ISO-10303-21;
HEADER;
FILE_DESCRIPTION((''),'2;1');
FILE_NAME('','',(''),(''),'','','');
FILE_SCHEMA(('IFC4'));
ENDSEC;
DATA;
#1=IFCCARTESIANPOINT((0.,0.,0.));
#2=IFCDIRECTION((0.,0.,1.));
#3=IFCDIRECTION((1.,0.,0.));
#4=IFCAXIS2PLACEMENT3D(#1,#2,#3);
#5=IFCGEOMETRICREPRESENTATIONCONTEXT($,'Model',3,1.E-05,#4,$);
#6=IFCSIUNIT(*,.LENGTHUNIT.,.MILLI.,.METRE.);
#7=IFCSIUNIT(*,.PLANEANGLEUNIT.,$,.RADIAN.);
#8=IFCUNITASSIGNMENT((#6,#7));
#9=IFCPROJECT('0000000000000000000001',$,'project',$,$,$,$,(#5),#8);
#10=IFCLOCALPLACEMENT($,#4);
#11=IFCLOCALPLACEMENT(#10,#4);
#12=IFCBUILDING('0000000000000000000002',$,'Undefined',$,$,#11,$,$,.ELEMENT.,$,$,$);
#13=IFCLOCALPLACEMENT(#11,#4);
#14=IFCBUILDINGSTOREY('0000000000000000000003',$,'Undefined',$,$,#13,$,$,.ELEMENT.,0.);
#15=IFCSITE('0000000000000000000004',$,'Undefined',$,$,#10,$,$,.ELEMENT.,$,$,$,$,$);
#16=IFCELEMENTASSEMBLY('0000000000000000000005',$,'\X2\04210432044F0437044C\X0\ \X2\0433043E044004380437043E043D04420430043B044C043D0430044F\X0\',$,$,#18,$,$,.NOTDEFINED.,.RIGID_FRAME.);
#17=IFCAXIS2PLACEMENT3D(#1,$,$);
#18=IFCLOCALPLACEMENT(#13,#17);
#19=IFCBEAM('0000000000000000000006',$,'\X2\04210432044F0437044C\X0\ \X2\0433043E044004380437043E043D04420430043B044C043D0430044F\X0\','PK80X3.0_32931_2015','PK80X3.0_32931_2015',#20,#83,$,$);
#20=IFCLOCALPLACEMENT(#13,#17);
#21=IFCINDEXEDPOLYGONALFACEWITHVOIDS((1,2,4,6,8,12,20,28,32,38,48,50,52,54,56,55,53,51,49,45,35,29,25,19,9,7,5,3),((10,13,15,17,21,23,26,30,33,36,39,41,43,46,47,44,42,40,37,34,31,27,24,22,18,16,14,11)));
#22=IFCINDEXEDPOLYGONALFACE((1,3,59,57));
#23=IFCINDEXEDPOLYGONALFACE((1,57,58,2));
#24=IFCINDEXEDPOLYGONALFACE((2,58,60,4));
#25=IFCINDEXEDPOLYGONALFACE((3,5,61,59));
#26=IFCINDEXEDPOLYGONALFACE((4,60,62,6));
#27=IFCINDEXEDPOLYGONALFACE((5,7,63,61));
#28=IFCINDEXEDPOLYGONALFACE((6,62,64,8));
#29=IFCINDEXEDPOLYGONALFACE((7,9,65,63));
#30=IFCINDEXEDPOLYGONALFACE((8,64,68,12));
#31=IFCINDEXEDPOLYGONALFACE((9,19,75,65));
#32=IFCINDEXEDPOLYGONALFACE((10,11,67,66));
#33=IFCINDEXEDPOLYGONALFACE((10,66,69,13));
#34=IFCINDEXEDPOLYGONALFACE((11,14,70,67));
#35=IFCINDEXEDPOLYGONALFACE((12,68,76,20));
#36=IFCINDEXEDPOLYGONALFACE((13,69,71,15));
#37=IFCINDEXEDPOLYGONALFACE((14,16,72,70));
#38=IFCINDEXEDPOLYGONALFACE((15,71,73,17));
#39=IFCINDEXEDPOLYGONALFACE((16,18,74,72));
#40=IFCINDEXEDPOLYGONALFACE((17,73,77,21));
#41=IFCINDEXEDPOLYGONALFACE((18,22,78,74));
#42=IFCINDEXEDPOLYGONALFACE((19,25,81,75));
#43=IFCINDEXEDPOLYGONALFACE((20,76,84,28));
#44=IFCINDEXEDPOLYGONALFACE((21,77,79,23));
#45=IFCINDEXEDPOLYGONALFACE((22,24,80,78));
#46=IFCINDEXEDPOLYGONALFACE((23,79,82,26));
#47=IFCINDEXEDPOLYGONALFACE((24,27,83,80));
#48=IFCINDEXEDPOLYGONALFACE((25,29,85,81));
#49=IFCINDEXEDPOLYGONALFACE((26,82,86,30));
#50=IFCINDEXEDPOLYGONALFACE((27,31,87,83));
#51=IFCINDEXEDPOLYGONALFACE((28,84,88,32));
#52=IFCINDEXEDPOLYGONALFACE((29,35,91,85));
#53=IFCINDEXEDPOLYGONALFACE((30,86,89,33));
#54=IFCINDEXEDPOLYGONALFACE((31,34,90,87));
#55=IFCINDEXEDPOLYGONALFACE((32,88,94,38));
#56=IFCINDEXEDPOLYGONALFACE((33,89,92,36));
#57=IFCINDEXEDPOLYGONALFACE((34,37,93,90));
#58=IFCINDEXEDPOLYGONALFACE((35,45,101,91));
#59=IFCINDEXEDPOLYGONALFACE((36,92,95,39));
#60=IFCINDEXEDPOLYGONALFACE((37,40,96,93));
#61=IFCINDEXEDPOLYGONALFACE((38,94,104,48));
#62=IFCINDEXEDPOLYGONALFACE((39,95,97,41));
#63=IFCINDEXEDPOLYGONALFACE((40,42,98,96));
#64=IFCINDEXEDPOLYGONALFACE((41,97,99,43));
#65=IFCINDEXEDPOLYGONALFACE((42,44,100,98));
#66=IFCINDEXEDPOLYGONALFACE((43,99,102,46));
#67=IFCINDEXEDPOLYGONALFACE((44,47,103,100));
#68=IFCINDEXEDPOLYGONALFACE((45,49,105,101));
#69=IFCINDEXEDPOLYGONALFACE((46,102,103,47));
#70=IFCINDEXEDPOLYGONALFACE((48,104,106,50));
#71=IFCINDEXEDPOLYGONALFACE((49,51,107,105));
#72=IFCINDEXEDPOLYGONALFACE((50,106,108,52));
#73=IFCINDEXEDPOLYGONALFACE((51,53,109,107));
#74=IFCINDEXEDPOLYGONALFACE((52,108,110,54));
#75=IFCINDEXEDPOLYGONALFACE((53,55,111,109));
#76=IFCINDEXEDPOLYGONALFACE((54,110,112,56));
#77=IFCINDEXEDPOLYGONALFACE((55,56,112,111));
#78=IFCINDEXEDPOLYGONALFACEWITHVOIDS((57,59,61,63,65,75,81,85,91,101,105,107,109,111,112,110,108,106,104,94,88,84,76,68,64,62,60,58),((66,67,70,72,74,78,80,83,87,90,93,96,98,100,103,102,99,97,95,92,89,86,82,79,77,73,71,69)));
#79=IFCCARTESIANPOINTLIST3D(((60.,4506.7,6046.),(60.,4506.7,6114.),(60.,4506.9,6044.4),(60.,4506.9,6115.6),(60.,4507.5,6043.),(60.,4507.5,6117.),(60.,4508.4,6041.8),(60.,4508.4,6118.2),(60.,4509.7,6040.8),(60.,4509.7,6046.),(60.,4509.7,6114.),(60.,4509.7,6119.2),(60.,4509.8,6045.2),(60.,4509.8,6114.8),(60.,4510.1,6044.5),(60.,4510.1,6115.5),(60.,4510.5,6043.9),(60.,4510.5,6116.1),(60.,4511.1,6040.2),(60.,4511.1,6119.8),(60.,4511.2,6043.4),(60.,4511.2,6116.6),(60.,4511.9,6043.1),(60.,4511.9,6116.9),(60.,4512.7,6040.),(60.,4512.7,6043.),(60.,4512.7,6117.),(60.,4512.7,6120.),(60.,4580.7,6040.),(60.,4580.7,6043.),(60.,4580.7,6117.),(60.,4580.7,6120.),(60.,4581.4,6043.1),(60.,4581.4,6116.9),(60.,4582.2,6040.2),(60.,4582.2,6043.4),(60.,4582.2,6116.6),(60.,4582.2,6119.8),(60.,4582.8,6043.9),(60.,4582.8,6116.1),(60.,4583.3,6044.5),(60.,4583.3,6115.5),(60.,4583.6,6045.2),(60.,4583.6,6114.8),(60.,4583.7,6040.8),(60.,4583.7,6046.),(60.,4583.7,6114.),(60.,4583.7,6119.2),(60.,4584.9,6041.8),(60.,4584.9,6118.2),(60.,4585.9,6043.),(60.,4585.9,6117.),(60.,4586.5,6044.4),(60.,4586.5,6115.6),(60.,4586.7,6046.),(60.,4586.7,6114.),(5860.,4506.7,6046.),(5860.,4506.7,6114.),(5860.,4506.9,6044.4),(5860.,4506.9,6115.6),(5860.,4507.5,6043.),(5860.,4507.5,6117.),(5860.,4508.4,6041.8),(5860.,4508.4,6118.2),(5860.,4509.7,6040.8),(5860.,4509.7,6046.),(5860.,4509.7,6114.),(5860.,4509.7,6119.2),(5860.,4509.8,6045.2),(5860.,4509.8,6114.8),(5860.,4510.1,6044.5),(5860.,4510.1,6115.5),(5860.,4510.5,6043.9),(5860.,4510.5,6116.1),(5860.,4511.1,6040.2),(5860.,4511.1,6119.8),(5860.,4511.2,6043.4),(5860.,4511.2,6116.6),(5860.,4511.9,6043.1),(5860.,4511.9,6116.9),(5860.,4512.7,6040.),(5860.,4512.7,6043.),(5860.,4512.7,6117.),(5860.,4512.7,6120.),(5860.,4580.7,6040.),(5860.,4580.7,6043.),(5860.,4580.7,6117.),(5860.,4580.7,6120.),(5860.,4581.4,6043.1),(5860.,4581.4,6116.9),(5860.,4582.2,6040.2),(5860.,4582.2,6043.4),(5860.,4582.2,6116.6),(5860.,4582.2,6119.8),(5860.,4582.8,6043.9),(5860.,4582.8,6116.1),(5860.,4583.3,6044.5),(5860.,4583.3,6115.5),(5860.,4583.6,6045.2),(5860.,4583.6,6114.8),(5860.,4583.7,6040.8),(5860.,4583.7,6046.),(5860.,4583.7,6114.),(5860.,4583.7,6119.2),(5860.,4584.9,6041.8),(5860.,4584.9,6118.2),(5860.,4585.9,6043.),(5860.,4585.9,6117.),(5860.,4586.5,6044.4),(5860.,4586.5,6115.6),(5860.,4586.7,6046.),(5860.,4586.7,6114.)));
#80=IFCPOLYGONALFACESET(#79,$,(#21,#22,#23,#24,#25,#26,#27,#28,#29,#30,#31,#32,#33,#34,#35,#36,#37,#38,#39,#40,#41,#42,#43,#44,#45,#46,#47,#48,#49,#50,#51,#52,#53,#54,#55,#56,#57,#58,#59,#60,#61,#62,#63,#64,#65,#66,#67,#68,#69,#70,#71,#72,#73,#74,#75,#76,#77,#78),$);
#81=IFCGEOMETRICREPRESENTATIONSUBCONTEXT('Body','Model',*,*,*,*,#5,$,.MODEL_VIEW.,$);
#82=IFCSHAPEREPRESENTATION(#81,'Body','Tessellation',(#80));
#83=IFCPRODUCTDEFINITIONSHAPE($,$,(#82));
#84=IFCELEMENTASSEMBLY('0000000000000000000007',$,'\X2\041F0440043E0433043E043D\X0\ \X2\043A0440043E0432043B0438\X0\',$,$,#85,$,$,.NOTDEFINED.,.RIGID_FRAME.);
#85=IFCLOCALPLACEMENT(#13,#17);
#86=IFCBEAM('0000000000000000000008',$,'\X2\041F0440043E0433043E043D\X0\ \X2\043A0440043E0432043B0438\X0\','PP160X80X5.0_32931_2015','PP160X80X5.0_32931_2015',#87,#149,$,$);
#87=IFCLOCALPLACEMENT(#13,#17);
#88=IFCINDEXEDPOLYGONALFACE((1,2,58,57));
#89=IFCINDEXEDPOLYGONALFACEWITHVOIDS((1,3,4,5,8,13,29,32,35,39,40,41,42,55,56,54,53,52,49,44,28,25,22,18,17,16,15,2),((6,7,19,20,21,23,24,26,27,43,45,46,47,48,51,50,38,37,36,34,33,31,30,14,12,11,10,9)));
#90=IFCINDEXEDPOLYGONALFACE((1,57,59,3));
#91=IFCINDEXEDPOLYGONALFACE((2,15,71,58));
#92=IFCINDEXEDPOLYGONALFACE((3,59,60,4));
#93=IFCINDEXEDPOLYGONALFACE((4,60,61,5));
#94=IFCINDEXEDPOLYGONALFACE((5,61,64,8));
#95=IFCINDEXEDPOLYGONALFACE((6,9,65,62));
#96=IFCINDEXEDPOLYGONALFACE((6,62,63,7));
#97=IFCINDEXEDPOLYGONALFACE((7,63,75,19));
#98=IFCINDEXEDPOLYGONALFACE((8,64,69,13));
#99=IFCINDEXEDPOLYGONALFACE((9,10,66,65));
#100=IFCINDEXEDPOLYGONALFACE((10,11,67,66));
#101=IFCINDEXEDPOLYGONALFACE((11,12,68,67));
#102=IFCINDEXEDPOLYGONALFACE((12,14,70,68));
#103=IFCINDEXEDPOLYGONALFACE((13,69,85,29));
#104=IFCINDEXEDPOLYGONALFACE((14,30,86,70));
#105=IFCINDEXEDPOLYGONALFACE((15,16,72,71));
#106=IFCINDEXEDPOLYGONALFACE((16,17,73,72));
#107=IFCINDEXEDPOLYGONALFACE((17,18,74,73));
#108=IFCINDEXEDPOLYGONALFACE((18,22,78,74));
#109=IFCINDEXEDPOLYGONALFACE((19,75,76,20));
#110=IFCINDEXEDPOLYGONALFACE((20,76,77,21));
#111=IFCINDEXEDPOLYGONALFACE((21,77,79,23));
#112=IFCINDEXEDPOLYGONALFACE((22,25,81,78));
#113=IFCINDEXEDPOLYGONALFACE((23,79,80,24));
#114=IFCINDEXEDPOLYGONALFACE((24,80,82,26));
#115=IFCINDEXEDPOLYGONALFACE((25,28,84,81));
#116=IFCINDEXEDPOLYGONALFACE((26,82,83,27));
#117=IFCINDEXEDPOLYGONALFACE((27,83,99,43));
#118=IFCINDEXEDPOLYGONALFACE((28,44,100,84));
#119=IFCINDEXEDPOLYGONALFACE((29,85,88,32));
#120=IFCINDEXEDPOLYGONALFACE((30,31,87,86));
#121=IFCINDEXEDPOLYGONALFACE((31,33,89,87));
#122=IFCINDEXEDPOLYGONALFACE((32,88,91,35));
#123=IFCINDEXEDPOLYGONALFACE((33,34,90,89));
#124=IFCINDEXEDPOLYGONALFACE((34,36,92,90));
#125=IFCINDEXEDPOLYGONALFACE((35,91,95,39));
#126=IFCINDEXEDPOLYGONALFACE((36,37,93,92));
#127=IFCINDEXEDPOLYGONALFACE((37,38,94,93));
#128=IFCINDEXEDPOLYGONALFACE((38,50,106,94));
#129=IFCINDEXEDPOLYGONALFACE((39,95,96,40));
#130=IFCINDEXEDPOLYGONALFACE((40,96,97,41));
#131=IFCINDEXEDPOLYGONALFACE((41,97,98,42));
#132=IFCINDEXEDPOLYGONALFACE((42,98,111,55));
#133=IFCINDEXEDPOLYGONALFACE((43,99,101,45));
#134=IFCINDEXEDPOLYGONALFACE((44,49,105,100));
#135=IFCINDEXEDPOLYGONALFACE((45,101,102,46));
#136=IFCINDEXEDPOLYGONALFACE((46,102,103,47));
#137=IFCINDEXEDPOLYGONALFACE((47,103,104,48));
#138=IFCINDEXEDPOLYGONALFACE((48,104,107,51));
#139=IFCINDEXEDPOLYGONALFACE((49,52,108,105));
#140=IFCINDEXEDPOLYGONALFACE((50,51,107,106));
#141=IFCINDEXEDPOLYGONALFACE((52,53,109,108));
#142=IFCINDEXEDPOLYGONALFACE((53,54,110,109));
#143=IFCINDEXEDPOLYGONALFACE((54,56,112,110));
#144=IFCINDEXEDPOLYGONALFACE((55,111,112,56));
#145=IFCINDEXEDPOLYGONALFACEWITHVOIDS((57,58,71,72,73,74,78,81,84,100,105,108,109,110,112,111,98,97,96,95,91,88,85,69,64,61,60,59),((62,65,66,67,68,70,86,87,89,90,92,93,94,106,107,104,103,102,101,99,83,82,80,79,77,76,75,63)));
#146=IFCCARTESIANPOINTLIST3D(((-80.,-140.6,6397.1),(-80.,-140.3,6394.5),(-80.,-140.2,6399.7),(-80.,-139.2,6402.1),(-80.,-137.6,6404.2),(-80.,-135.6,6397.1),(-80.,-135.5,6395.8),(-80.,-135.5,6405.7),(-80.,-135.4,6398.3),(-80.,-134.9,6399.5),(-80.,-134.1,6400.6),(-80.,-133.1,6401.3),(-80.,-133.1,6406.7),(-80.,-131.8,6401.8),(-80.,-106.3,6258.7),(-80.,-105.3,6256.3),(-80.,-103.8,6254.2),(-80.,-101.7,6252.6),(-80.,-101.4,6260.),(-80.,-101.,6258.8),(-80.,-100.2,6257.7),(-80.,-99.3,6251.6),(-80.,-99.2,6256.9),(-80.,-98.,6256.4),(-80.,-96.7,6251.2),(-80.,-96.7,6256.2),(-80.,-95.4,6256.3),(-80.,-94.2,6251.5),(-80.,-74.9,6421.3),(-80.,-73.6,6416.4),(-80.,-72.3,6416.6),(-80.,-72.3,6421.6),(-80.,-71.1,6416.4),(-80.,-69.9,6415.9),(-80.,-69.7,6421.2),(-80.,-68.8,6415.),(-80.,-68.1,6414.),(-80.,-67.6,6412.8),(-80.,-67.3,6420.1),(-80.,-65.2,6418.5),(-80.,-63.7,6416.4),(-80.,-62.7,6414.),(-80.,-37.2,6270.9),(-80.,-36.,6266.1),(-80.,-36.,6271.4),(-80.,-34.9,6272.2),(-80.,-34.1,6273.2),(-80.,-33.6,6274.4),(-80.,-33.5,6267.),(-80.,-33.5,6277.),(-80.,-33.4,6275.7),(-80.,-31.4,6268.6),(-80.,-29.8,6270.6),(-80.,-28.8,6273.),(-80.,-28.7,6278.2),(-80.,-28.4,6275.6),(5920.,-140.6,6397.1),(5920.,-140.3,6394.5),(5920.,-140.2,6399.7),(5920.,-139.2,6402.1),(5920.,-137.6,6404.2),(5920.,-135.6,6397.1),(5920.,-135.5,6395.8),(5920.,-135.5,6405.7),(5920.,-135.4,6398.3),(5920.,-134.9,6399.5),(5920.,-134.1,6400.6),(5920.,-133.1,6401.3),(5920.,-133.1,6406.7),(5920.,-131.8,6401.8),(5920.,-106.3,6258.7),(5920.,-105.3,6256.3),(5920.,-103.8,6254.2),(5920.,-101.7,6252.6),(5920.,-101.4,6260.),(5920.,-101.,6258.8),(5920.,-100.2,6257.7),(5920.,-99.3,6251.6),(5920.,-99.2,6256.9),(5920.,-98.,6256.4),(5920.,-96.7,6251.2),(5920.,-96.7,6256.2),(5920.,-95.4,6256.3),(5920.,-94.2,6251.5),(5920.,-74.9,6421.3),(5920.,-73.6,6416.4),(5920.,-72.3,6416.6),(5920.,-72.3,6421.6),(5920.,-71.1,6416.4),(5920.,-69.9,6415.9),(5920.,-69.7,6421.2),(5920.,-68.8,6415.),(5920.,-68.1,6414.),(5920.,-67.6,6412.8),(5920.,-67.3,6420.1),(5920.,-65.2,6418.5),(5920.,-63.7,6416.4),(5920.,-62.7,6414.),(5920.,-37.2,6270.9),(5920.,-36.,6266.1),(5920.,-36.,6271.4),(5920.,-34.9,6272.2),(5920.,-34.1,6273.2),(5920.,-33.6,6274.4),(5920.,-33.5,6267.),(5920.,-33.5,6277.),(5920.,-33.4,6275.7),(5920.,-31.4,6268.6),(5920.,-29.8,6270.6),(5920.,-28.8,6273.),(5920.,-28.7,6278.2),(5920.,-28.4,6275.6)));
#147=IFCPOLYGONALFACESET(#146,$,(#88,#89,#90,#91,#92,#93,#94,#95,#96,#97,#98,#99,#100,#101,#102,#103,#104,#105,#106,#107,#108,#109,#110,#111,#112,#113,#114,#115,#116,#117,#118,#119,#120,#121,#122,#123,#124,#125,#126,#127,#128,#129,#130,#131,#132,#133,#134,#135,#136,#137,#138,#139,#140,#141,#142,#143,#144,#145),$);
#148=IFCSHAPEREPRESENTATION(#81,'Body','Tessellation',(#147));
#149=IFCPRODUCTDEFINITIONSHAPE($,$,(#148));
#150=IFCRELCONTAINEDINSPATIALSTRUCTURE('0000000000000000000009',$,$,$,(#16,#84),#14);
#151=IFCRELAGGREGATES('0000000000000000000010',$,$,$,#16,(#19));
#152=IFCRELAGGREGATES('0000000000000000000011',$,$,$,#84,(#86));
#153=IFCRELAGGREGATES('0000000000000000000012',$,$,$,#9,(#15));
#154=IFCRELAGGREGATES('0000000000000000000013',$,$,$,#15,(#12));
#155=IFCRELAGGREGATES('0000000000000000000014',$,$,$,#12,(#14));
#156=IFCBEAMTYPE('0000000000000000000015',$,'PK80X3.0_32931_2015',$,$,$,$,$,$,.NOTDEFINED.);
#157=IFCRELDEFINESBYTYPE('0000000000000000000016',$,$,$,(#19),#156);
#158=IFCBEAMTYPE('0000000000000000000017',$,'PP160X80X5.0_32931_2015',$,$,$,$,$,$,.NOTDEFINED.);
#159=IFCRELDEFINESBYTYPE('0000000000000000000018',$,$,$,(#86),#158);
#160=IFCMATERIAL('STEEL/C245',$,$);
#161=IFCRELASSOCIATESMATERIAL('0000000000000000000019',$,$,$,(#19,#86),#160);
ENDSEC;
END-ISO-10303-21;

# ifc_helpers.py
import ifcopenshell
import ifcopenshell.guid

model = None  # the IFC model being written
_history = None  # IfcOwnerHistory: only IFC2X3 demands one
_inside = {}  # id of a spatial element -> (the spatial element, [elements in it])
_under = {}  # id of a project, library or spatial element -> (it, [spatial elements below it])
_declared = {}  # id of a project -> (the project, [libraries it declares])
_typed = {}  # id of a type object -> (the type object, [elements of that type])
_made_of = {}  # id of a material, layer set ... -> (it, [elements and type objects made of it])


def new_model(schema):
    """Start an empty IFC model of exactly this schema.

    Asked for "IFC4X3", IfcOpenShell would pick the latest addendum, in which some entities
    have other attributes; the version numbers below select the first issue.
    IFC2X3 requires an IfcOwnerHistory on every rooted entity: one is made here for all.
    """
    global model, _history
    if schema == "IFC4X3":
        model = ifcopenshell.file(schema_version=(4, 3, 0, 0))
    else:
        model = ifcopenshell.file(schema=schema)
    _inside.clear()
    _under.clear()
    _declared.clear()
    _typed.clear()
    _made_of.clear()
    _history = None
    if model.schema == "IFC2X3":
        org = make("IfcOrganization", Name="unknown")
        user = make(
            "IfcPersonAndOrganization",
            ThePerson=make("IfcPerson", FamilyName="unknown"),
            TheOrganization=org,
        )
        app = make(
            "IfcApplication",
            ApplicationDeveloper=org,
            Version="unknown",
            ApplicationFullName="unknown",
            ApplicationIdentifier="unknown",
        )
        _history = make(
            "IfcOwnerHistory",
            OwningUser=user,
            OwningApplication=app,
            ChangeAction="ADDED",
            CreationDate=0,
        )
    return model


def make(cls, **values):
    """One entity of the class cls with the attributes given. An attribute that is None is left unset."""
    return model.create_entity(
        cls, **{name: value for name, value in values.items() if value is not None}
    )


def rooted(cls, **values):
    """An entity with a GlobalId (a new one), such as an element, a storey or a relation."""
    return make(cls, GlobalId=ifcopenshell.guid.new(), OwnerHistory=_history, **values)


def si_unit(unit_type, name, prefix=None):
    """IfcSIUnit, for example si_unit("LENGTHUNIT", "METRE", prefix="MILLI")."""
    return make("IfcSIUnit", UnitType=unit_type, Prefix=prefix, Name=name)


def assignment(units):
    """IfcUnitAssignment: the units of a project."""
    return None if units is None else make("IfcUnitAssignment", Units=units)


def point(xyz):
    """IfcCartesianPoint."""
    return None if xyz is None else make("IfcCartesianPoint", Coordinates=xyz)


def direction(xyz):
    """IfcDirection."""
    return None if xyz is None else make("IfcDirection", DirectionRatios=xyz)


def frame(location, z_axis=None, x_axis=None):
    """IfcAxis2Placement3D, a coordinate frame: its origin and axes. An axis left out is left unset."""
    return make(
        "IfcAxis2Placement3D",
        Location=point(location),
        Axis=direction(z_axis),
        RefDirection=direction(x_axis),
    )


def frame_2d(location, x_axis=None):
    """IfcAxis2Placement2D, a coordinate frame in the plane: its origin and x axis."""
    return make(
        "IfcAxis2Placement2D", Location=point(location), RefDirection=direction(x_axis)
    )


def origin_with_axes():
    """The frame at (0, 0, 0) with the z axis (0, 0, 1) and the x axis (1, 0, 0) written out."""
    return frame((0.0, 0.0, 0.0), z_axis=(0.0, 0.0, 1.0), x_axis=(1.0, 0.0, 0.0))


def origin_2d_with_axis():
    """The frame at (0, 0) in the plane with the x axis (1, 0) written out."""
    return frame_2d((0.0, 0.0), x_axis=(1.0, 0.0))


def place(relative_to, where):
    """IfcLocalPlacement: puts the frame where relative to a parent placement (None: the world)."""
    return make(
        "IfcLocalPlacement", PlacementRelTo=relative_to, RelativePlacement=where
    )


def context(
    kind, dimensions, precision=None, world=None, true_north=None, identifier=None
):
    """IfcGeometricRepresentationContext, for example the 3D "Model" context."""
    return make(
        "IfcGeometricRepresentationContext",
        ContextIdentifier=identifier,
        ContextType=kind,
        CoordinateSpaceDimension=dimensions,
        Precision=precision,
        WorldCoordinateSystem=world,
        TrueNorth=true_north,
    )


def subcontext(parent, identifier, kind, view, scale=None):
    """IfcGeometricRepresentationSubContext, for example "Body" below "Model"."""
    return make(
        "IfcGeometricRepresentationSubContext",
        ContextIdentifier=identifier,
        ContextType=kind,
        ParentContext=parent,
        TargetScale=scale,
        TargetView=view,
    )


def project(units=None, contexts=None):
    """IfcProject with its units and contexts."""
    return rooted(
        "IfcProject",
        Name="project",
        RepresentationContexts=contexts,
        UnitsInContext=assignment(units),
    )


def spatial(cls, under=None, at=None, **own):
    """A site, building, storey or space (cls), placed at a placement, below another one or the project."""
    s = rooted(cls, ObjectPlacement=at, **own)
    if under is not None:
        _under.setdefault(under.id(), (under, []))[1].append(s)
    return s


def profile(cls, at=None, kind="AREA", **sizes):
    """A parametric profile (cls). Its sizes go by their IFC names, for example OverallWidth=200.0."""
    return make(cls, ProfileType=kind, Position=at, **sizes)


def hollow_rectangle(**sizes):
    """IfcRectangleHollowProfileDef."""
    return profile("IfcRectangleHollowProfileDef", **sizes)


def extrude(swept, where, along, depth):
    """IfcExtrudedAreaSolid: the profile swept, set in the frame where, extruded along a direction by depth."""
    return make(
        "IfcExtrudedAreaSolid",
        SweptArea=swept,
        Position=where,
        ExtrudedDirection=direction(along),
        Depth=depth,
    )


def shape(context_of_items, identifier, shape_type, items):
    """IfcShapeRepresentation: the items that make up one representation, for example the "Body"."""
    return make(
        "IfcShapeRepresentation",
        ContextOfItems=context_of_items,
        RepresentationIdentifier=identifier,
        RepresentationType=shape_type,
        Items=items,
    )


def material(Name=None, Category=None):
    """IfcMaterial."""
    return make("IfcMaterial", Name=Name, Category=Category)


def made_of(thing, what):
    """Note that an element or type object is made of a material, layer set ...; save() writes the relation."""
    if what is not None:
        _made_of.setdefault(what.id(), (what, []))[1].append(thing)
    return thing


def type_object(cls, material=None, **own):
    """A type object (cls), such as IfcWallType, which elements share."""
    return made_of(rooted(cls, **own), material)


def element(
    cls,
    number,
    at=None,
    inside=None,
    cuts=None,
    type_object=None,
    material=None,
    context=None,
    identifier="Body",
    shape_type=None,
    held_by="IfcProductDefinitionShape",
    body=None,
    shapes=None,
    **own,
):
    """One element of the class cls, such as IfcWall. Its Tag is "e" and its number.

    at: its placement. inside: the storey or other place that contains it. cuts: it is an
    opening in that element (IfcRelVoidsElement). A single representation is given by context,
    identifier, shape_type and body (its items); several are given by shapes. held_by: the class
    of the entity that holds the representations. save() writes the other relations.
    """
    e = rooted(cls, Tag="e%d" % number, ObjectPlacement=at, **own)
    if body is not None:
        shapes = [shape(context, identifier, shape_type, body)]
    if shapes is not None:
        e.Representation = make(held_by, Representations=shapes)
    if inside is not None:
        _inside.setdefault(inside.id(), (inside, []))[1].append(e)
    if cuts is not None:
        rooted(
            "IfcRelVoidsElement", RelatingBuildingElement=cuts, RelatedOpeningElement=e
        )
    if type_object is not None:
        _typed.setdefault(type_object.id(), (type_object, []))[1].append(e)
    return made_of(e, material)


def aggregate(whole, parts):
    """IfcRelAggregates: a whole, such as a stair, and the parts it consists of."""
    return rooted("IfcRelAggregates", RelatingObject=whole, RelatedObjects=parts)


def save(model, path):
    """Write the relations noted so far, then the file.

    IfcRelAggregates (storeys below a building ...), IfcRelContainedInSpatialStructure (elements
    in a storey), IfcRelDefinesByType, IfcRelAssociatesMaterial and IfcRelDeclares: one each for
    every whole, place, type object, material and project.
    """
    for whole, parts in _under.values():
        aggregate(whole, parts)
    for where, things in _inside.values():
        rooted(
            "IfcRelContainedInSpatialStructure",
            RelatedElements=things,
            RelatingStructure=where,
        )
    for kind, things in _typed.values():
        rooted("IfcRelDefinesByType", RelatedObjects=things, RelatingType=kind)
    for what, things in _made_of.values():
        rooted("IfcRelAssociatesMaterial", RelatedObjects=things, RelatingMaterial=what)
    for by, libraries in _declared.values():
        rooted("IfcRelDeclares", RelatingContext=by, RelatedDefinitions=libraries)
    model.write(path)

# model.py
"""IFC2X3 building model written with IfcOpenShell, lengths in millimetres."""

from ifc_helpers import new_model, si_unit, frame, origin_with_axes, origin_2d_with_axis, place, context, subcontext, project, spatial, hollow_rectangle, extrude, material, type_object, element, aggregate, save


model = new_model("IFC2X3")

# Units and contexts
model_context = context("Model", 3, precision=1e-05, world=origin_with_axes())
body_context = subcontext(model_context, "Body", "Model", "MODEL_VIEW")
ifc_project = project(units=[si_unit("LENGTHUNIT", "METRE", prefix="MILLI"), si_unit("PLANEANGLEUNIT", "RADIAN")], contexts=[model_context])

# Site, building, storey
site_placement = place(None, origin_with_axes())
site = spatial("IfcSite", under=ifc_project, at=site_placement, Name="Undefined", CompositionType="ELEMENT")
building_placement = place(site_placement, origin_with_axes())
building = spatial("IfcBuilding", under=site, at=building_placement, Name="Undefined", CompositionType="ELEMENT")
storey_placement = place(building_placement, origin_with_axes())
storey = spatial("IfcBuildingStorey", under=building, at=storey_placement, Name="Undefined", CompositionType="ELEMENT", Elevation=0.0)

# Shared definitions
ifc_material = material(Name="STEEL/C245")

# Element assemblies, beams
beam_type_1 = type_object("IfcBeamType", Name="PK80X3.0_32931_2015", PredefinedType="NOTDEFINED")
assembly_1_placement = place(storey_placement, origin_with_axes())
assembly_1 = element("IfcElementAssembly", 1, at=assembly_1_placement, inside=storey, Name="Связь горизонтальная", AssemblyPlace="NOTDEFINED", PredefinedType="RIGID_FRAME")
beam_1_placement = place(assembly_1_placement, frame((60.0, 4546.7, 6080.0), z_axis=(0.0, 0.0, 1.0), x_axis=(1.0, 0.0, 0.0)))
beam_1 = element("IfcBeam", 2, at=beam_1_placement, type_object=beam_type_1, material=ifc_material, Name="Связь горизонтальная", Description="PK80X3.0_32931_2015", ObjectType="PK80X3.0_32931_2015", context=body_context, shape_type="SweptSolid", body=[
    extrude(hollow_rectangle(XDim=80.0, YDim=80.0, WallThickness=3.0, InnerFilletRadius=3.0, OuterFilletRadius=6.0, at=origin_2d_with_axis()), frame((5800.0, 0.0, 0.0), z_axis=(-1.0, 0.0, 0.0), x_axis=(0.0, -1.0, 0.0)), (0.0, 0.0, 1.0), 5800.0),
])
aggregate(assembly_1, [beam_1])
assembly_2_placement = place(storey_placement, origin_with_axes())
assembly_2 = element("IfcElementAssembly", 3, at=assembly_2_placement, inside=storey, Name="Прогон кровли", AssemblyPlace="NOTDEFINED", PredefinedType="RIGID_FRAME")
beam_type_2 = type_object("IfcBeamType", Name="PP160X80X5.0_32931_2015", PredefinedType="NOTDEFINED")
beam_2_placement = place(assembly_2_placement, frame((-80.0, -84.5, 6336.4), z_axis=(0.0, -0.243188, 0.969979), x_axis=(1.0, 0.0, 0.0)))
beam_2 = element("IfcBeam", 4, at=beam_2_placement, type_object=beam_type_2, material=ifc_material, Name="Прогон кровли", Description="PP160X80X5.0_32931_2015", ObjectType="PP160X80X5.0_32931_2015", context=body_context, shape_type="SweptSolid", body=[
    extrude(hollow_rectangle(XDim=80.0, YDim=160.0, WallThickness=5.0, InnerFilletRadius=5.0, OuterFilletRadius=10.0, at=origin_2d_with_axis()), frame((6000.0, 0.0, 0.0), z_axis=(-1.0, 0.0, 0.0), x_axis=(0.0, -1.0, 0.0)), (0.0, 0.0, 1.0), 6000.0),
])
aggregate(assembly_2, [beam_2])

save(model, "model.ifc")
